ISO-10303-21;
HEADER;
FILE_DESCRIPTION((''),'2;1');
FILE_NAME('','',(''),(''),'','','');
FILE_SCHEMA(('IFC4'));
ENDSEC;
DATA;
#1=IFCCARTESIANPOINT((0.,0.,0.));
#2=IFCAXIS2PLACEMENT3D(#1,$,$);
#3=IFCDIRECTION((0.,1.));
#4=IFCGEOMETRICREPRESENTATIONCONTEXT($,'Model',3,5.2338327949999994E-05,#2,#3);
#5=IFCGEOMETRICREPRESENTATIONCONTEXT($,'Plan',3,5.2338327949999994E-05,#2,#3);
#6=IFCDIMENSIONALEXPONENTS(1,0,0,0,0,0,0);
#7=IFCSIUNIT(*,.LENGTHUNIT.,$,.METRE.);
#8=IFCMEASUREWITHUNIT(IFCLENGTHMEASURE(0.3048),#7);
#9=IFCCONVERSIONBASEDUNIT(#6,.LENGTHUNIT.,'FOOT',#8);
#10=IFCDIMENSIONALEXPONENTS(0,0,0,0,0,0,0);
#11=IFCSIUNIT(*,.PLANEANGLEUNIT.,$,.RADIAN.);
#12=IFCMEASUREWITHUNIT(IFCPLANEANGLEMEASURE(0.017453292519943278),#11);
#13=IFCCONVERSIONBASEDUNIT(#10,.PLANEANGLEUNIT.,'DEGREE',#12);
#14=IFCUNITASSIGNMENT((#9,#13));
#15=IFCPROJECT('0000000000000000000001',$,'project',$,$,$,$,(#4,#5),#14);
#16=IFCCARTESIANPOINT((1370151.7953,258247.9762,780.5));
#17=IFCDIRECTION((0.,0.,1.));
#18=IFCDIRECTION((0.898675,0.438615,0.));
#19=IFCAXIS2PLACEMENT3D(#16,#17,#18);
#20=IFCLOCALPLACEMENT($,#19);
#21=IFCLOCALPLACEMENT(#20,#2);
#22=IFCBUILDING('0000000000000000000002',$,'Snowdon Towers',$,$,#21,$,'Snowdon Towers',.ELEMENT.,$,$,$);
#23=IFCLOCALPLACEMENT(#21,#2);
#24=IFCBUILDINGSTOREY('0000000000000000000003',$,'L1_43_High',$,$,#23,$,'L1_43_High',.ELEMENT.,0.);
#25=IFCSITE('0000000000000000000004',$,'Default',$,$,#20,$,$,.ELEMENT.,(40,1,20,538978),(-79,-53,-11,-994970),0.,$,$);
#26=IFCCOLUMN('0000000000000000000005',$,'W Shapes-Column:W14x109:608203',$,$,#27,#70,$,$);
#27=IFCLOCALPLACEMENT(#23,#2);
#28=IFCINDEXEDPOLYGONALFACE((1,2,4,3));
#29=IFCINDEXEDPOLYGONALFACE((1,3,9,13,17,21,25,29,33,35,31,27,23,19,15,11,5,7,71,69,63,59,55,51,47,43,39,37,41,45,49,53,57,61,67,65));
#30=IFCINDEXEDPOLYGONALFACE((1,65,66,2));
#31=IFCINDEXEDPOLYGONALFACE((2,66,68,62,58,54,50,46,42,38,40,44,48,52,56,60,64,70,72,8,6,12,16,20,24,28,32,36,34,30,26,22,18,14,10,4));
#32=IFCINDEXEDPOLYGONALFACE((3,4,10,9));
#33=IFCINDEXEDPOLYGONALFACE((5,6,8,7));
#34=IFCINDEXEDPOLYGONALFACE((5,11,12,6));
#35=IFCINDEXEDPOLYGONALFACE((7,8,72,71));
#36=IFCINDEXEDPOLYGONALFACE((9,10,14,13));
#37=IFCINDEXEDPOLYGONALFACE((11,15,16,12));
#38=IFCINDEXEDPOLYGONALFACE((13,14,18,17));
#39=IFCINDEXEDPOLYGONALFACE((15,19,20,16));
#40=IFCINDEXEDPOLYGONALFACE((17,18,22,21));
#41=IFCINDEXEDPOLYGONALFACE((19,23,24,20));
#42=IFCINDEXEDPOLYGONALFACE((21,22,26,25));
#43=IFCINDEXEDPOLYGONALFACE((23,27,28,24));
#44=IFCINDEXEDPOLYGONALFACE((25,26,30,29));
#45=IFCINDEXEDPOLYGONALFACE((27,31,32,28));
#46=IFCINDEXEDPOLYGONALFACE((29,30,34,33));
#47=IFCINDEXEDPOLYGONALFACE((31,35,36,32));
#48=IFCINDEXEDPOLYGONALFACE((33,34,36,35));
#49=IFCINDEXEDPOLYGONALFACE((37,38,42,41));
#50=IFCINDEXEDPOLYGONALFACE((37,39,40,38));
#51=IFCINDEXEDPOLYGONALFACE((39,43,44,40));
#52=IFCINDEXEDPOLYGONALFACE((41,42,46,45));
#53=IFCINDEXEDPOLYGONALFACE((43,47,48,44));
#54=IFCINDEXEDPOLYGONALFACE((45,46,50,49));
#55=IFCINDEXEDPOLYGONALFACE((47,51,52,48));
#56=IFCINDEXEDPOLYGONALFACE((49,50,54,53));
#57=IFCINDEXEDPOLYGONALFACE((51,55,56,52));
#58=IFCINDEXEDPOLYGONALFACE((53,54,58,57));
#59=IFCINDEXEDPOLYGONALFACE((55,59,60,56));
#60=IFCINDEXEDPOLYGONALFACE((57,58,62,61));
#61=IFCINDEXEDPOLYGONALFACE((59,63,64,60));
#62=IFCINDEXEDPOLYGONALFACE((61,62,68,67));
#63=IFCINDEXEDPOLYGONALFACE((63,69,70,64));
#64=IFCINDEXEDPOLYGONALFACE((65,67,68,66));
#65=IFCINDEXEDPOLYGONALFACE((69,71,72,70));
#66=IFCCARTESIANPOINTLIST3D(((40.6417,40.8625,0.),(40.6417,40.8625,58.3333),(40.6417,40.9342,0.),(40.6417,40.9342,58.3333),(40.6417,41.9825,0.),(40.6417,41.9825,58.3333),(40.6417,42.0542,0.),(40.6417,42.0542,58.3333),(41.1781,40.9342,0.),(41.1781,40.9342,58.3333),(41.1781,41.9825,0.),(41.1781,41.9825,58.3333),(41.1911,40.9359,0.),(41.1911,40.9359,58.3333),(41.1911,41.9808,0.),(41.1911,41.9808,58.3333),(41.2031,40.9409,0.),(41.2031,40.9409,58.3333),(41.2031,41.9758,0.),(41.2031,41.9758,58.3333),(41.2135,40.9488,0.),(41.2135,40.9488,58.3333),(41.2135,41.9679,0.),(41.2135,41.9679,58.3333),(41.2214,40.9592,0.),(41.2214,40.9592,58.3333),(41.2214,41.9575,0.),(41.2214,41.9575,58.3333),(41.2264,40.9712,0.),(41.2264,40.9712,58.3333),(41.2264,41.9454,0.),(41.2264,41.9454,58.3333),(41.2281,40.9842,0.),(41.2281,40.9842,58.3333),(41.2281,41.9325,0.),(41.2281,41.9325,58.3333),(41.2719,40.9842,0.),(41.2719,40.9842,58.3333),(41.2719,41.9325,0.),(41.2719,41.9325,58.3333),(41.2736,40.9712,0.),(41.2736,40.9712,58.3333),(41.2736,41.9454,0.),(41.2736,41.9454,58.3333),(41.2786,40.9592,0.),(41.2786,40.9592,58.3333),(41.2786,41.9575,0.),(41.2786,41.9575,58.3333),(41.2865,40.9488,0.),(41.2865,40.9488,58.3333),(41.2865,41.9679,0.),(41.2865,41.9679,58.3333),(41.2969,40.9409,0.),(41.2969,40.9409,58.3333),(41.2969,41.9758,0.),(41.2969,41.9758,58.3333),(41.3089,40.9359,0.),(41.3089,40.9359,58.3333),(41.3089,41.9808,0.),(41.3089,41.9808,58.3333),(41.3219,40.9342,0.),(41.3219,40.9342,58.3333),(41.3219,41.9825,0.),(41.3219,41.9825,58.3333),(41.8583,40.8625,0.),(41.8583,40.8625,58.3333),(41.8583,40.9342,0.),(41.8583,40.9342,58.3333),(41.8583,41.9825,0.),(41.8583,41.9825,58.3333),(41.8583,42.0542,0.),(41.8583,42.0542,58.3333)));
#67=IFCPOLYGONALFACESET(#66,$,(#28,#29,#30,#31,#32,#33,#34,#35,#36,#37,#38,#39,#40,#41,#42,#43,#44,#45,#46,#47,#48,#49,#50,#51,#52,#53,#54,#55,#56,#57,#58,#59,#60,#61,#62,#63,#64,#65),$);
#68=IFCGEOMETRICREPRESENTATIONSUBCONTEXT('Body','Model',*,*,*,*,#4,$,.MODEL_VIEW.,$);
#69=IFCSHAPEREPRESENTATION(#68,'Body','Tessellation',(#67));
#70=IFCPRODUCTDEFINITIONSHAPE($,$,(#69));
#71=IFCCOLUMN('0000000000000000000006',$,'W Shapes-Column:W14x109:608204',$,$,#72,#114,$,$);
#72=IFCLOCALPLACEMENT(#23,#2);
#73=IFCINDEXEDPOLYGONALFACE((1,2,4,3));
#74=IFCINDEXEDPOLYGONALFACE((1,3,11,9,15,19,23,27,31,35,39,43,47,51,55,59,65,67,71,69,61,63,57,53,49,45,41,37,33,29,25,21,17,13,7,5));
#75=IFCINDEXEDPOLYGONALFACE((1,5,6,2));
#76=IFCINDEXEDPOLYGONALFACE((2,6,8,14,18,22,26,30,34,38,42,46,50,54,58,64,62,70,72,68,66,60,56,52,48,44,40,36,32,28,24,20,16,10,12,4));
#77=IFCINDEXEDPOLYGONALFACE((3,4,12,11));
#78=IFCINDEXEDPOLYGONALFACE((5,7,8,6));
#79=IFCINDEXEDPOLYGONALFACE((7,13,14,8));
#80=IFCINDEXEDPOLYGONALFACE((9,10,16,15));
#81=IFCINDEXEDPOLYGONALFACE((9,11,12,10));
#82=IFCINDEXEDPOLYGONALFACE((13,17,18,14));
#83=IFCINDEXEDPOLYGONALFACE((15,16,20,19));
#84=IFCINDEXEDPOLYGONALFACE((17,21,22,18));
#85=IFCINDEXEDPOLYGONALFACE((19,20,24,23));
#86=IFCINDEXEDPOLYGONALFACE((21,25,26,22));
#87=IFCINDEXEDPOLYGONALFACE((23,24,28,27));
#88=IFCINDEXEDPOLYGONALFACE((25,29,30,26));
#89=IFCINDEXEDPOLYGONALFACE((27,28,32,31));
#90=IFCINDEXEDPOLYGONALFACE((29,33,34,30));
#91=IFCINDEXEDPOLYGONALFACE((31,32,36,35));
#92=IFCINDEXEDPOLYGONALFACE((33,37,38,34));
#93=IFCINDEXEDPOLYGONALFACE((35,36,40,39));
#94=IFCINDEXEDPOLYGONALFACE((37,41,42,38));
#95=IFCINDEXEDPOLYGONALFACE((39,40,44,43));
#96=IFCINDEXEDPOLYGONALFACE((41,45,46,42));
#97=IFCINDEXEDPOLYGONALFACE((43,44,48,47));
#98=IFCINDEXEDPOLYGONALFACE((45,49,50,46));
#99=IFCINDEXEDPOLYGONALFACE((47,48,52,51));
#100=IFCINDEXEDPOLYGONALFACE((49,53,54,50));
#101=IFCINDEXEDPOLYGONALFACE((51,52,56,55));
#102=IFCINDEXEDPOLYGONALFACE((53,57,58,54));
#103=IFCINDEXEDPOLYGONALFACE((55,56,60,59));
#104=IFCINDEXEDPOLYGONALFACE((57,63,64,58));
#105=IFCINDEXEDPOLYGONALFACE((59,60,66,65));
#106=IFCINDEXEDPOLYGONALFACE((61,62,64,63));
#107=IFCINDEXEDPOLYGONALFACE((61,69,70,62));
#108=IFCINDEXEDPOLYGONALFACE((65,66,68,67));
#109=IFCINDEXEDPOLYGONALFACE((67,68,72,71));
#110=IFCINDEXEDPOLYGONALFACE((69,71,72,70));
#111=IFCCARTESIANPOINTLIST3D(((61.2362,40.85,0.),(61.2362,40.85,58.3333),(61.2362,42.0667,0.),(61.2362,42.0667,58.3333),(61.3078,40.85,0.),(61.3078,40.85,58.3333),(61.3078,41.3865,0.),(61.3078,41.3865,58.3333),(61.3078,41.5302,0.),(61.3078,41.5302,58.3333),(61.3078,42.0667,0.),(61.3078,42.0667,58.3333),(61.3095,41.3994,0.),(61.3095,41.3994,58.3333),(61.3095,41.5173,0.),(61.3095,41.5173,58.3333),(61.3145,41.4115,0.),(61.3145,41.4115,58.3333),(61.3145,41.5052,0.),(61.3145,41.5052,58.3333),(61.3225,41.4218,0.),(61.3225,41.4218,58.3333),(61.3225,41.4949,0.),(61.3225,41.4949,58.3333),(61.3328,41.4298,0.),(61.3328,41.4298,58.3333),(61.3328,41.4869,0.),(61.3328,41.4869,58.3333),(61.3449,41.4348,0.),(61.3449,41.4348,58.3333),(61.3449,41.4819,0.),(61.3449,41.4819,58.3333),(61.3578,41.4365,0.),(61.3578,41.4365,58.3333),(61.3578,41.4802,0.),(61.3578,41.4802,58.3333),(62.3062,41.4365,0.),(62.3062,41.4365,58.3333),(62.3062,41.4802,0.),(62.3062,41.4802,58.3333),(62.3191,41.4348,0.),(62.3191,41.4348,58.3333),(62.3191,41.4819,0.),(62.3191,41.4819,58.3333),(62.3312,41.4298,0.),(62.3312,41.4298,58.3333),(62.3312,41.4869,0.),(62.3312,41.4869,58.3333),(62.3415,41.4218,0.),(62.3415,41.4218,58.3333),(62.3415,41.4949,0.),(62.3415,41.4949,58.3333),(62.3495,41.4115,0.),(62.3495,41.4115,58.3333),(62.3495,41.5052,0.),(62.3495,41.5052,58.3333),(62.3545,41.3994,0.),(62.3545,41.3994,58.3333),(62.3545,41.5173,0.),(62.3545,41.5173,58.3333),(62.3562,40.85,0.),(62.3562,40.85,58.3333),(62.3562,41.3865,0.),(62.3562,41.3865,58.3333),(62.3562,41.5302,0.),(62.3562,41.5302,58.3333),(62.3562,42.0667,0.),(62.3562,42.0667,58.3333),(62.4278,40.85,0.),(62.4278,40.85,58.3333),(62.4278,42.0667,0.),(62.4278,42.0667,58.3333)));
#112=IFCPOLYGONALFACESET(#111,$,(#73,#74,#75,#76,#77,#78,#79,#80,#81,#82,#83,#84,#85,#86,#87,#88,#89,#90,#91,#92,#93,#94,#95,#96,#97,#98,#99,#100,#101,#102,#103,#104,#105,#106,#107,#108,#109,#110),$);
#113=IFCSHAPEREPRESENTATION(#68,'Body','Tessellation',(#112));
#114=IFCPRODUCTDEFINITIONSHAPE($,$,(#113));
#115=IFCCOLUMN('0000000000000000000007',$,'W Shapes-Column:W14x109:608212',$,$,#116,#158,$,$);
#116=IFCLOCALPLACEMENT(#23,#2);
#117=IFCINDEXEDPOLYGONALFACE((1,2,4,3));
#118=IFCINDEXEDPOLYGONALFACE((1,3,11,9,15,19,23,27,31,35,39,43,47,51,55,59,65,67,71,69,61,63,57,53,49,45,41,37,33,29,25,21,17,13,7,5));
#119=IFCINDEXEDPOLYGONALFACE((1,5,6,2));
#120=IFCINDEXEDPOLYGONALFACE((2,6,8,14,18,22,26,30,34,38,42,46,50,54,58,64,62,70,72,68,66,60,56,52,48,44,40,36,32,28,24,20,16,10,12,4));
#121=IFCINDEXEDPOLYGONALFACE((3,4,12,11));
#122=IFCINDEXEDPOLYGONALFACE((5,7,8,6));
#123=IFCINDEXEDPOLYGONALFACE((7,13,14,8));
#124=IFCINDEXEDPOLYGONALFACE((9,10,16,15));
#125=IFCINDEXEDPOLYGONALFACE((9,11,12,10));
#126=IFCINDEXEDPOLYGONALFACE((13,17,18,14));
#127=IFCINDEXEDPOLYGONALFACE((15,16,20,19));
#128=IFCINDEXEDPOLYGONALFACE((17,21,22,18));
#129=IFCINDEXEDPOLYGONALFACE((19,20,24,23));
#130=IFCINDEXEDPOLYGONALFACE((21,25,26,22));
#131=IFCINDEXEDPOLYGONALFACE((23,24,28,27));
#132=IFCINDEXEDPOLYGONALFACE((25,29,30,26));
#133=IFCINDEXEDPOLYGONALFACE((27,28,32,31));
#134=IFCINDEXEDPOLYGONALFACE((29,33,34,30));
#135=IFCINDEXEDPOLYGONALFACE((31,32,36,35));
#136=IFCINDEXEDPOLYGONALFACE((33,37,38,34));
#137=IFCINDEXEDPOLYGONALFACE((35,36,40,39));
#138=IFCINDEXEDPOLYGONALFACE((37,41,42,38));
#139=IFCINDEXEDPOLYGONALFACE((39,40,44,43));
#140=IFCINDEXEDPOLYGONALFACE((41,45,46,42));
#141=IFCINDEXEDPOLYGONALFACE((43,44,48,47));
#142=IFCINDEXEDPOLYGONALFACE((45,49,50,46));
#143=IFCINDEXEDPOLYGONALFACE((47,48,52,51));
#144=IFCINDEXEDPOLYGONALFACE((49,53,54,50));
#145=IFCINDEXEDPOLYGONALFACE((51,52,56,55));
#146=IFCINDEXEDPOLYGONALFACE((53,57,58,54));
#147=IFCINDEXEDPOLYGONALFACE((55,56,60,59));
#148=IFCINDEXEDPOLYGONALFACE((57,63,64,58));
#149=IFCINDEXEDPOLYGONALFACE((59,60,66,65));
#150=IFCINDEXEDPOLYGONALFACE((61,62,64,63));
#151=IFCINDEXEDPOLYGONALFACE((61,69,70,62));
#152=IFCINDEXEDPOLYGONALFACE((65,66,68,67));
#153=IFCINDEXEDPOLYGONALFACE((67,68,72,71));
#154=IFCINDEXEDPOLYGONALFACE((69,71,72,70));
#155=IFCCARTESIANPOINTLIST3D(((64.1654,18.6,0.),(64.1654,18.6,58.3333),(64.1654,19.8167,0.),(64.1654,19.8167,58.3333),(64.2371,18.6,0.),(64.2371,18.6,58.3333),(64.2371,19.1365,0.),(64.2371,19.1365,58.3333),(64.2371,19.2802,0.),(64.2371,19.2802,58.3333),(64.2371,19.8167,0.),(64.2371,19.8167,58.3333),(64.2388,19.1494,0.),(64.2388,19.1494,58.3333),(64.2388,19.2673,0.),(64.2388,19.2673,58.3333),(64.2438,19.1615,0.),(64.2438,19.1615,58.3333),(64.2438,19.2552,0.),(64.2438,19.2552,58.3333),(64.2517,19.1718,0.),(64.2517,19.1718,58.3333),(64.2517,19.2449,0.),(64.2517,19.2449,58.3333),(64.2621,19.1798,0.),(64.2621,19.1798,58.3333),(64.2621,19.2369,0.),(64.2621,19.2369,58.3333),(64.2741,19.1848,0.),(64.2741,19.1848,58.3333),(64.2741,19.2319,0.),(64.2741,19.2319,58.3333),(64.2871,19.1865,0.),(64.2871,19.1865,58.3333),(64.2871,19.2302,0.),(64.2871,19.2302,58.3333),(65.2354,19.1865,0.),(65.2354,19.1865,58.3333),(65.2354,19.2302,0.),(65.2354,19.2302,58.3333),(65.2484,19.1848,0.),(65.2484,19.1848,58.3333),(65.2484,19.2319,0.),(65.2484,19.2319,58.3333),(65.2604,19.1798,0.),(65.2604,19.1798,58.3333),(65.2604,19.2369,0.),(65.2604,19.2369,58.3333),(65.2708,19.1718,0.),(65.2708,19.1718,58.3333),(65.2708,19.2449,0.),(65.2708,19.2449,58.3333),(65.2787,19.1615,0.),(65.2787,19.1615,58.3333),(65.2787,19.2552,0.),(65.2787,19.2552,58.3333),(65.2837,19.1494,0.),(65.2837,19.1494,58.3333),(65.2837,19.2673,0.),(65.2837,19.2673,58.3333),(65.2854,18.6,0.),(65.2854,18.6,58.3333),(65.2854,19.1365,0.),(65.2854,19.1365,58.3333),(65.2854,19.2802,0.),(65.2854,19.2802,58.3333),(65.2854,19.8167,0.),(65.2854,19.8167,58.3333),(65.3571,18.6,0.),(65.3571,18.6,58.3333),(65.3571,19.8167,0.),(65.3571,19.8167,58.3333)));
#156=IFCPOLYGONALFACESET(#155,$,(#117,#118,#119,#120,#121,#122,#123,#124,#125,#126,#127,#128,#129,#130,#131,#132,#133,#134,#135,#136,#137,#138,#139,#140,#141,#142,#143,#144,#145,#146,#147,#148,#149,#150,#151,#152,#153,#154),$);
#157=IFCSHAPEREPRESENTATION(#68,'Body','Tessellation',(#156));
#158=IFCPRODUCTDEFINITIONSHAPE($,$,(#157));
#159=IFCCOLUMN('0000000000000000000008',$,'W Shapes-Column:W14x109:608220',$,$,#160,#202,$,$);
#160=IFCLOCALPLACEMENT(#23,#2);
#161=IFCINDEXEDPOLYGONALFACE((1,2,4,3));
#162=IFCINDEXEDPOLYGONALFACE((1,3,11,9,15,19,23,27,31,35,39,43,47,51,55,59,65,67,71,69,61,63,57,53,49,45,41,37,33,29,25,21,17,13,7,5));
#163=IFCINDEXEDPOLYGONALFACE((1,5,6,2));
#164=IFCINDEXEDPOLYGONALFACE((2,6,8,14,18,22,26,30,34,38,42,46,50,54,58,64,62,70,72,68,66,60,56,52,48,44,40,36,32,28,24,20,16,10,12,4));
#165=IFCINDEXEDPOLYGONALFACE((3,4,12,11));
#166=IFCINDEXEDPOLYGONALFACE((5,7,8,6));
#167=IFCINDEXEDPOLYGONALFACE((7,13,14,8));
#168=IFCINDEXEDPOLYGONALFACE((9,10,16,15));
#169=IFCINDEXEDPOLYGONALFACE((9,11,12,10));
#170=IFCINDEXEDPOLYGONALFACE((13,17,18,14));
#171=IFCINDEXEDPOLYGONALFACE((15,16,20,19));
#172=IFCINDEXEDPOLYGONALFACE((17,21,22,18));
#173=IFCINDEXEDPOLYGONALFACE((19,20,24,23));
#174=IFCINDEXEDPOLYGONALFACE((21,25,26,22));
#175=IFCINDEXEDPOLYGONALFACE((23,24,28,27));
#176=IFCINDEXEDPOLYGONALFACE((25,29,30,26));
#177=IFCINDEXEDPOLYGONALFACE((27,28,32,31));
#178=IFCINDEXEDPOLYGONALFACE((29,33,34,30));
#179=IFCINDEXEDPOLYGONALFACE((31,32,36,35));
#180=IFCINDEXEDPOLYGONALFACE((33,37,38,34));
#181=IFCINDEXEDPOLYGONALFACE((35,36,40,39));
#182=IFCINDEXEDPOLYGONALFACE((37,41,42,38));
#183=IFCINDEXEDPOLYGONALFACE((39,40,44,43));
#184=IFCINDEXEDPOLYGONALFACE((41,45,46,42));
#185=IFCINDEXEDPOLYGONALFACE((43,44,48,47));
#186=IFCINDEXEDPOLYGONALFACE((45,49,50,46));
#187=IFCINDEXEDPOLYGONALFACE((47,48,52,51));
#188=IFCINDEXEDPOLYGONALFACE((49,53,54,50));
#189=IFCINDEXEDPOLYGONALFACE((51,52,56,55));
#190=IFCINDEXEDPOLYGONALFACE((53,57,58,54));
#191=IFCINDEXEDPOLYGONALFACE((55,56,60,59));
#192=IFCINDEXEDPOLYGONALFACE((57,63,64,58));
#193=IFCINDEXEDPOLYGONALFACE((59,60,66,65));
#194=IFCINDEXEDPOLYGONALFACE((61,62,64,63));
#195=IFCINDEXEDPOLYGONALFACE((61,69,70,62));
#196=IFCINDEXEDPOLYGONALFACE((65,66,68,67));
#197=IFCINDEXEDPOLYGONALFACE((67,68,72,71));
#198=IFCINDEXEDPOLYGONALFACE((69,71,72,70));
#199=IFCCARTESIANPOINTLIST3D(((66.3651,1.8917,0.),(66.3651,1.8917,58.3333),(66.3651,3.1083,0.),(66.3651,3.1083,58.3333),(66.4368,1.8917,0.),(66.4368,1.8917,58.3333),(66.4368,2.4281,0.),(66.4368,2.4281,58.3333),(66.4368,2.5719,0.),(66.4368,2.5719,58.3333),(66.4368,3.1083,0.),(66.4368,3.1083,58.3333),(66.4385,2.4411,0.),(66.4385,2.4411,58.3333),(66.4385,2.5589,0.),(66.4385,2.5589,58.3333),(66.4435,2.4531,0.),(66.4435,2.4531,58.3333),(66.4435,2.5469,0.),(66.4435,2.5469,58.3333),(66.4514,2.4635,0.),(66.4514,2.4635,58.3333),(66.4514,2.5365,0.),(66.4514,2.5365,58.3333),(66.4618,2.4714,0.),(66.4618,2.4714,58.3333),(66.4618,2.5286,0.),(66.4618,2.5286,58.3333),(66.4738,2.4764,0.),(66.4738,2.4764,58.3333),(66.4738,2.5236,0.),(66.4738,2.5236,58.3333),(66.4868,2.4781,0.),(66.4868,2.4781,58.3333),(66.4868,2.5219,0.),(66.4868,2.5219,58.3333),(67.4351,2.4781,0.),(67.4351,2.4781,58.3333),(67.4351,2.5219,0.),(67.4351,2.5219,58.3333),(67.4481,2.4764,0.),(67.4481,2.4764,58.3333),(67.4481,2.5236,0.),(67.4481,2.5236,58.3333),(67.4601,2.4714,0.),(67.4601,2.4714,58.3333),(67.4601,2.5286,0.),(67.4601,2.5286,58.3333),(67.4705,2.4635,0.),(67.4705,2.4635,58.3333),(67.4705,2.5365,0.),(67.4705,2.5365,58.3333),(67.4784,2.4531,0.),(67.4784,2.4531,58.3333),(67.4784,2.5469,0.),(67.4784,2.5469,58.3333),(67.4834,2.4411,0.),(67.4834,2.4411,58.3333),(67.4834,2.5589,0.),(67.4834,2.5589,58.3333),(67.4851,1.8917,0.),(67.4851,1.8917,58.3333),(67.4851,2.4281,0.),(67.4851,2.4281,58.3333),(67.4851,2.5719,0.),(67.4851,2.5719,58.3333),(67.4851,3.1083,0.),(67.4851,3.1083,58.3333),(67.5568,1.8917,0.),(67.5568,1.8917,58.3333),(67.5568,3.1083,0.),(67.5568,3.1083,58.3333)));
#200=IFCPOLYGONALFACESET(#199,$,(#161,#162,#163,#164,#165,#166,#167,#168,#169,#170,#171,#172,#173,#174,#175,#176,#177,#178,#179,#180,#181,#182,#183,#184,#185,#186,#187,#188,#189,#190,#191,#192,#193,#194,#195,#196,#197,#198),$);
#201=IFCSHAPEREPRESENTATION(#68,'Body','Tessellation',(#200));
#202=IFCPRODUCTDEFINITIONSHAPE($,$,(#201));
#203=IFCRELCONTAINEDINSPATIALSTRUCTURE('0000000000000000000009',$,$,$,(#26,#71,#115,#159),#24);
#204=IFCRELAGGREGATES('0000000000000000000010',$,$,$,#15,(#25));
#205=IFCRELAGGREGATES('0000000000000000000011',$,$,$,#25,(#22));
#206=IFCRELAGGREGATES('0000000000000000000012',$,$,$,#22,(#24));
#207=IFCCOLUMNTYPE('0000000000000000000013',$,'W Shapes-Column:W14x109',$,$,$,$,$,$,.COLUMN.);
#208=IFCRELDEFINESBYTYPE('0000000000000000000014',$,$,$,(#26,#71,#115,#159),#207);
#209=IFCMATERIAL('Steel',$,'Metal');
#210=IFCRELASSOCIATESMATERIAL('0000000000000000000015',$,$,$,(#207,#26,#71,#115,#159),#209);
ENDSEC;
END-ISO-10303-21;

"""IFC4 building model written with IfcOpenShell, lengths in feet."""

from ifc_helpers import new_model, entity, si_unit, converted_unit, direction, frame, origin, place, context, subcontext, project, spatial, line, arc, indexed_curve, outline, extrude, source, transform, mapped, material, type_object, type_shapes, element, save


model = new_model("IFC4")

# Units and contexts
model_context = context("Model", 3, precision=5.2338327949999994e-05, world=origin(), true_north=direction((0.0, 1.0)))
plan_context = context("Plan", 3, precision=5.2338327949999994e-05, world=origin(), true_north=direction((0.0, 1.0)))
body_context = subcontext(model_context, "Body", "Model", "MODEL_VIEW")
ifc_project = project(units=[converted_unit("LENGTHUNIT", "FOOT", entity("IfcLengthMeasure", 0.3048), si_unit("LENGTHUNIT", "METRE"), dimensions=[1, 0, 0, 0, 0, 0, 0]), converted_unit("PLANEANGLEUNIT", "DEGREE", entity("IfcPlaneAngleMeasure", 0.017453292519943278), si_unit("PLANEANGLEUNIT", "RADIAN"), dimensions=[0, 0, 0, 0, 0, 0, 0])], contexts=[model_context, plan_context])

# Site, building, storey
site_placement = place(None, frame((1370151.7953, 258247.9762, 780.5), z_axis=(0.0, 0.0, 1.0), x_axis=(0.898675, 0.438615, 0.0)))
site = spatial("IfcSite", under=ifc_project, at=site_placement, Name="Default", CompositionType="ELEMENT", RefLatitude=(40, 1, 20, 538978), RefLongitude=(-79, -53, -11, -994970), RefElevation=0.0)
building_placement = place(site_placement, origin())
building = spatial("IfcBuilding", under=site, at=building_placement, Name="Snowdon Towers", LongName="Snowdon Towers", CompositionType="ELEMENT")
storey_placement = place(building_placement, origin())
storey = spatial("IfcBuildingStorey", under=building, at=storey_placement, Name="L1_43_High", LongName="L1_43_High", CompositionType="ELEMENT", Elevation=0.0)

# Columns
ifc_material_1 = material(Name="Steel", Category="Metal")
column_type_1 = type_object("IfcColumnType", Name="W Shapes-Column:W14x109", PredefinedType="COLUMN", material=ifc_material_1)
shared_shape_1 = source(origin(), body_context, "Body", "SweptSolid", [
    extrude(outline(indexed_curve([(-0.6083, -0.5958), (0.6083, -0.5958), (0.6083, -0.5242), (0.0719, -0.5242), (0.0365, -0.5095), (0.0219, -0.4742), (0.0219, 0.4742), (0.0365, 0.5095), (0.0719, 0.5242), (0.6083, 0.5242), (0.6083, 0.5958), (-0.6083, 0.5958), (-0.6083, 0.5242), (-0.0719, 0.5242), (-0.0365, 0.5095), (-0.0219, 0.4742), (-0.0219, -0.4742), (-0.0365, -0.5095), (-0.0719, -0.5242), (-0.6083, -0.5242)], segments=[line(1, 2, 3, 4), arc(4, 5, 6), line(6, 7), arc(7, 8, 9), line(9, 10, 11, 12, 13, 14), arc(14, 15, 16), line(16, 17), arc(17, 18, 19), line(19, 20, 1)], self_intersect=False)), frame((0.0, 0.0, 0.0), z_axis=(0.0, 0.0, 1.0), x_axis=(-1.0, 0.0, 0.0)), (0.0, 0.0, 1.0), 58.3333),
])
type_shapes(column_type_1, [shared_shape_1])
for number, where, z_axis, x_axis, name in (
    (1, (41.25, 41.4583, 0.0), (0.0, 0.0, 1.0), (-1.0, 0.0, 0.0), "W Shapes-Column:W14x109:608203"),
    (2, (61.832, 41.4583, 0.0), (0.0, 0.0, 1.0), (0.0, 1.0, 0.0), "W Shapes-Column:W14x109:608204"),
    (3, (64.7613, 19.2083, 0.0), (0.0, 0.0, 1.0), (0.0, 1.0, 0.0), "W Shapes-Column:W14x109:608212"),
    (4, (66.961, 2.5, 0.0), (0.0, 0.0, 1.0), (0.0, 1.0, 0.0), "W Shapes-Column:W14x109:608220"),
):
    element("IfcColumn", number, at=place(storey_placement, frame(where, z_axis=z_axis, x_axis=x_axis)), inside=storey, type_object=column_type_1, material=ifc_material_1, Name=name, context=body_context, shape_type="MappedRepresentation", body=[
        mapped(shared_shape_1, transform((0.0, 0.0, 0.0), scale=1.0)),
    ])

save(model, "model.ifc")
